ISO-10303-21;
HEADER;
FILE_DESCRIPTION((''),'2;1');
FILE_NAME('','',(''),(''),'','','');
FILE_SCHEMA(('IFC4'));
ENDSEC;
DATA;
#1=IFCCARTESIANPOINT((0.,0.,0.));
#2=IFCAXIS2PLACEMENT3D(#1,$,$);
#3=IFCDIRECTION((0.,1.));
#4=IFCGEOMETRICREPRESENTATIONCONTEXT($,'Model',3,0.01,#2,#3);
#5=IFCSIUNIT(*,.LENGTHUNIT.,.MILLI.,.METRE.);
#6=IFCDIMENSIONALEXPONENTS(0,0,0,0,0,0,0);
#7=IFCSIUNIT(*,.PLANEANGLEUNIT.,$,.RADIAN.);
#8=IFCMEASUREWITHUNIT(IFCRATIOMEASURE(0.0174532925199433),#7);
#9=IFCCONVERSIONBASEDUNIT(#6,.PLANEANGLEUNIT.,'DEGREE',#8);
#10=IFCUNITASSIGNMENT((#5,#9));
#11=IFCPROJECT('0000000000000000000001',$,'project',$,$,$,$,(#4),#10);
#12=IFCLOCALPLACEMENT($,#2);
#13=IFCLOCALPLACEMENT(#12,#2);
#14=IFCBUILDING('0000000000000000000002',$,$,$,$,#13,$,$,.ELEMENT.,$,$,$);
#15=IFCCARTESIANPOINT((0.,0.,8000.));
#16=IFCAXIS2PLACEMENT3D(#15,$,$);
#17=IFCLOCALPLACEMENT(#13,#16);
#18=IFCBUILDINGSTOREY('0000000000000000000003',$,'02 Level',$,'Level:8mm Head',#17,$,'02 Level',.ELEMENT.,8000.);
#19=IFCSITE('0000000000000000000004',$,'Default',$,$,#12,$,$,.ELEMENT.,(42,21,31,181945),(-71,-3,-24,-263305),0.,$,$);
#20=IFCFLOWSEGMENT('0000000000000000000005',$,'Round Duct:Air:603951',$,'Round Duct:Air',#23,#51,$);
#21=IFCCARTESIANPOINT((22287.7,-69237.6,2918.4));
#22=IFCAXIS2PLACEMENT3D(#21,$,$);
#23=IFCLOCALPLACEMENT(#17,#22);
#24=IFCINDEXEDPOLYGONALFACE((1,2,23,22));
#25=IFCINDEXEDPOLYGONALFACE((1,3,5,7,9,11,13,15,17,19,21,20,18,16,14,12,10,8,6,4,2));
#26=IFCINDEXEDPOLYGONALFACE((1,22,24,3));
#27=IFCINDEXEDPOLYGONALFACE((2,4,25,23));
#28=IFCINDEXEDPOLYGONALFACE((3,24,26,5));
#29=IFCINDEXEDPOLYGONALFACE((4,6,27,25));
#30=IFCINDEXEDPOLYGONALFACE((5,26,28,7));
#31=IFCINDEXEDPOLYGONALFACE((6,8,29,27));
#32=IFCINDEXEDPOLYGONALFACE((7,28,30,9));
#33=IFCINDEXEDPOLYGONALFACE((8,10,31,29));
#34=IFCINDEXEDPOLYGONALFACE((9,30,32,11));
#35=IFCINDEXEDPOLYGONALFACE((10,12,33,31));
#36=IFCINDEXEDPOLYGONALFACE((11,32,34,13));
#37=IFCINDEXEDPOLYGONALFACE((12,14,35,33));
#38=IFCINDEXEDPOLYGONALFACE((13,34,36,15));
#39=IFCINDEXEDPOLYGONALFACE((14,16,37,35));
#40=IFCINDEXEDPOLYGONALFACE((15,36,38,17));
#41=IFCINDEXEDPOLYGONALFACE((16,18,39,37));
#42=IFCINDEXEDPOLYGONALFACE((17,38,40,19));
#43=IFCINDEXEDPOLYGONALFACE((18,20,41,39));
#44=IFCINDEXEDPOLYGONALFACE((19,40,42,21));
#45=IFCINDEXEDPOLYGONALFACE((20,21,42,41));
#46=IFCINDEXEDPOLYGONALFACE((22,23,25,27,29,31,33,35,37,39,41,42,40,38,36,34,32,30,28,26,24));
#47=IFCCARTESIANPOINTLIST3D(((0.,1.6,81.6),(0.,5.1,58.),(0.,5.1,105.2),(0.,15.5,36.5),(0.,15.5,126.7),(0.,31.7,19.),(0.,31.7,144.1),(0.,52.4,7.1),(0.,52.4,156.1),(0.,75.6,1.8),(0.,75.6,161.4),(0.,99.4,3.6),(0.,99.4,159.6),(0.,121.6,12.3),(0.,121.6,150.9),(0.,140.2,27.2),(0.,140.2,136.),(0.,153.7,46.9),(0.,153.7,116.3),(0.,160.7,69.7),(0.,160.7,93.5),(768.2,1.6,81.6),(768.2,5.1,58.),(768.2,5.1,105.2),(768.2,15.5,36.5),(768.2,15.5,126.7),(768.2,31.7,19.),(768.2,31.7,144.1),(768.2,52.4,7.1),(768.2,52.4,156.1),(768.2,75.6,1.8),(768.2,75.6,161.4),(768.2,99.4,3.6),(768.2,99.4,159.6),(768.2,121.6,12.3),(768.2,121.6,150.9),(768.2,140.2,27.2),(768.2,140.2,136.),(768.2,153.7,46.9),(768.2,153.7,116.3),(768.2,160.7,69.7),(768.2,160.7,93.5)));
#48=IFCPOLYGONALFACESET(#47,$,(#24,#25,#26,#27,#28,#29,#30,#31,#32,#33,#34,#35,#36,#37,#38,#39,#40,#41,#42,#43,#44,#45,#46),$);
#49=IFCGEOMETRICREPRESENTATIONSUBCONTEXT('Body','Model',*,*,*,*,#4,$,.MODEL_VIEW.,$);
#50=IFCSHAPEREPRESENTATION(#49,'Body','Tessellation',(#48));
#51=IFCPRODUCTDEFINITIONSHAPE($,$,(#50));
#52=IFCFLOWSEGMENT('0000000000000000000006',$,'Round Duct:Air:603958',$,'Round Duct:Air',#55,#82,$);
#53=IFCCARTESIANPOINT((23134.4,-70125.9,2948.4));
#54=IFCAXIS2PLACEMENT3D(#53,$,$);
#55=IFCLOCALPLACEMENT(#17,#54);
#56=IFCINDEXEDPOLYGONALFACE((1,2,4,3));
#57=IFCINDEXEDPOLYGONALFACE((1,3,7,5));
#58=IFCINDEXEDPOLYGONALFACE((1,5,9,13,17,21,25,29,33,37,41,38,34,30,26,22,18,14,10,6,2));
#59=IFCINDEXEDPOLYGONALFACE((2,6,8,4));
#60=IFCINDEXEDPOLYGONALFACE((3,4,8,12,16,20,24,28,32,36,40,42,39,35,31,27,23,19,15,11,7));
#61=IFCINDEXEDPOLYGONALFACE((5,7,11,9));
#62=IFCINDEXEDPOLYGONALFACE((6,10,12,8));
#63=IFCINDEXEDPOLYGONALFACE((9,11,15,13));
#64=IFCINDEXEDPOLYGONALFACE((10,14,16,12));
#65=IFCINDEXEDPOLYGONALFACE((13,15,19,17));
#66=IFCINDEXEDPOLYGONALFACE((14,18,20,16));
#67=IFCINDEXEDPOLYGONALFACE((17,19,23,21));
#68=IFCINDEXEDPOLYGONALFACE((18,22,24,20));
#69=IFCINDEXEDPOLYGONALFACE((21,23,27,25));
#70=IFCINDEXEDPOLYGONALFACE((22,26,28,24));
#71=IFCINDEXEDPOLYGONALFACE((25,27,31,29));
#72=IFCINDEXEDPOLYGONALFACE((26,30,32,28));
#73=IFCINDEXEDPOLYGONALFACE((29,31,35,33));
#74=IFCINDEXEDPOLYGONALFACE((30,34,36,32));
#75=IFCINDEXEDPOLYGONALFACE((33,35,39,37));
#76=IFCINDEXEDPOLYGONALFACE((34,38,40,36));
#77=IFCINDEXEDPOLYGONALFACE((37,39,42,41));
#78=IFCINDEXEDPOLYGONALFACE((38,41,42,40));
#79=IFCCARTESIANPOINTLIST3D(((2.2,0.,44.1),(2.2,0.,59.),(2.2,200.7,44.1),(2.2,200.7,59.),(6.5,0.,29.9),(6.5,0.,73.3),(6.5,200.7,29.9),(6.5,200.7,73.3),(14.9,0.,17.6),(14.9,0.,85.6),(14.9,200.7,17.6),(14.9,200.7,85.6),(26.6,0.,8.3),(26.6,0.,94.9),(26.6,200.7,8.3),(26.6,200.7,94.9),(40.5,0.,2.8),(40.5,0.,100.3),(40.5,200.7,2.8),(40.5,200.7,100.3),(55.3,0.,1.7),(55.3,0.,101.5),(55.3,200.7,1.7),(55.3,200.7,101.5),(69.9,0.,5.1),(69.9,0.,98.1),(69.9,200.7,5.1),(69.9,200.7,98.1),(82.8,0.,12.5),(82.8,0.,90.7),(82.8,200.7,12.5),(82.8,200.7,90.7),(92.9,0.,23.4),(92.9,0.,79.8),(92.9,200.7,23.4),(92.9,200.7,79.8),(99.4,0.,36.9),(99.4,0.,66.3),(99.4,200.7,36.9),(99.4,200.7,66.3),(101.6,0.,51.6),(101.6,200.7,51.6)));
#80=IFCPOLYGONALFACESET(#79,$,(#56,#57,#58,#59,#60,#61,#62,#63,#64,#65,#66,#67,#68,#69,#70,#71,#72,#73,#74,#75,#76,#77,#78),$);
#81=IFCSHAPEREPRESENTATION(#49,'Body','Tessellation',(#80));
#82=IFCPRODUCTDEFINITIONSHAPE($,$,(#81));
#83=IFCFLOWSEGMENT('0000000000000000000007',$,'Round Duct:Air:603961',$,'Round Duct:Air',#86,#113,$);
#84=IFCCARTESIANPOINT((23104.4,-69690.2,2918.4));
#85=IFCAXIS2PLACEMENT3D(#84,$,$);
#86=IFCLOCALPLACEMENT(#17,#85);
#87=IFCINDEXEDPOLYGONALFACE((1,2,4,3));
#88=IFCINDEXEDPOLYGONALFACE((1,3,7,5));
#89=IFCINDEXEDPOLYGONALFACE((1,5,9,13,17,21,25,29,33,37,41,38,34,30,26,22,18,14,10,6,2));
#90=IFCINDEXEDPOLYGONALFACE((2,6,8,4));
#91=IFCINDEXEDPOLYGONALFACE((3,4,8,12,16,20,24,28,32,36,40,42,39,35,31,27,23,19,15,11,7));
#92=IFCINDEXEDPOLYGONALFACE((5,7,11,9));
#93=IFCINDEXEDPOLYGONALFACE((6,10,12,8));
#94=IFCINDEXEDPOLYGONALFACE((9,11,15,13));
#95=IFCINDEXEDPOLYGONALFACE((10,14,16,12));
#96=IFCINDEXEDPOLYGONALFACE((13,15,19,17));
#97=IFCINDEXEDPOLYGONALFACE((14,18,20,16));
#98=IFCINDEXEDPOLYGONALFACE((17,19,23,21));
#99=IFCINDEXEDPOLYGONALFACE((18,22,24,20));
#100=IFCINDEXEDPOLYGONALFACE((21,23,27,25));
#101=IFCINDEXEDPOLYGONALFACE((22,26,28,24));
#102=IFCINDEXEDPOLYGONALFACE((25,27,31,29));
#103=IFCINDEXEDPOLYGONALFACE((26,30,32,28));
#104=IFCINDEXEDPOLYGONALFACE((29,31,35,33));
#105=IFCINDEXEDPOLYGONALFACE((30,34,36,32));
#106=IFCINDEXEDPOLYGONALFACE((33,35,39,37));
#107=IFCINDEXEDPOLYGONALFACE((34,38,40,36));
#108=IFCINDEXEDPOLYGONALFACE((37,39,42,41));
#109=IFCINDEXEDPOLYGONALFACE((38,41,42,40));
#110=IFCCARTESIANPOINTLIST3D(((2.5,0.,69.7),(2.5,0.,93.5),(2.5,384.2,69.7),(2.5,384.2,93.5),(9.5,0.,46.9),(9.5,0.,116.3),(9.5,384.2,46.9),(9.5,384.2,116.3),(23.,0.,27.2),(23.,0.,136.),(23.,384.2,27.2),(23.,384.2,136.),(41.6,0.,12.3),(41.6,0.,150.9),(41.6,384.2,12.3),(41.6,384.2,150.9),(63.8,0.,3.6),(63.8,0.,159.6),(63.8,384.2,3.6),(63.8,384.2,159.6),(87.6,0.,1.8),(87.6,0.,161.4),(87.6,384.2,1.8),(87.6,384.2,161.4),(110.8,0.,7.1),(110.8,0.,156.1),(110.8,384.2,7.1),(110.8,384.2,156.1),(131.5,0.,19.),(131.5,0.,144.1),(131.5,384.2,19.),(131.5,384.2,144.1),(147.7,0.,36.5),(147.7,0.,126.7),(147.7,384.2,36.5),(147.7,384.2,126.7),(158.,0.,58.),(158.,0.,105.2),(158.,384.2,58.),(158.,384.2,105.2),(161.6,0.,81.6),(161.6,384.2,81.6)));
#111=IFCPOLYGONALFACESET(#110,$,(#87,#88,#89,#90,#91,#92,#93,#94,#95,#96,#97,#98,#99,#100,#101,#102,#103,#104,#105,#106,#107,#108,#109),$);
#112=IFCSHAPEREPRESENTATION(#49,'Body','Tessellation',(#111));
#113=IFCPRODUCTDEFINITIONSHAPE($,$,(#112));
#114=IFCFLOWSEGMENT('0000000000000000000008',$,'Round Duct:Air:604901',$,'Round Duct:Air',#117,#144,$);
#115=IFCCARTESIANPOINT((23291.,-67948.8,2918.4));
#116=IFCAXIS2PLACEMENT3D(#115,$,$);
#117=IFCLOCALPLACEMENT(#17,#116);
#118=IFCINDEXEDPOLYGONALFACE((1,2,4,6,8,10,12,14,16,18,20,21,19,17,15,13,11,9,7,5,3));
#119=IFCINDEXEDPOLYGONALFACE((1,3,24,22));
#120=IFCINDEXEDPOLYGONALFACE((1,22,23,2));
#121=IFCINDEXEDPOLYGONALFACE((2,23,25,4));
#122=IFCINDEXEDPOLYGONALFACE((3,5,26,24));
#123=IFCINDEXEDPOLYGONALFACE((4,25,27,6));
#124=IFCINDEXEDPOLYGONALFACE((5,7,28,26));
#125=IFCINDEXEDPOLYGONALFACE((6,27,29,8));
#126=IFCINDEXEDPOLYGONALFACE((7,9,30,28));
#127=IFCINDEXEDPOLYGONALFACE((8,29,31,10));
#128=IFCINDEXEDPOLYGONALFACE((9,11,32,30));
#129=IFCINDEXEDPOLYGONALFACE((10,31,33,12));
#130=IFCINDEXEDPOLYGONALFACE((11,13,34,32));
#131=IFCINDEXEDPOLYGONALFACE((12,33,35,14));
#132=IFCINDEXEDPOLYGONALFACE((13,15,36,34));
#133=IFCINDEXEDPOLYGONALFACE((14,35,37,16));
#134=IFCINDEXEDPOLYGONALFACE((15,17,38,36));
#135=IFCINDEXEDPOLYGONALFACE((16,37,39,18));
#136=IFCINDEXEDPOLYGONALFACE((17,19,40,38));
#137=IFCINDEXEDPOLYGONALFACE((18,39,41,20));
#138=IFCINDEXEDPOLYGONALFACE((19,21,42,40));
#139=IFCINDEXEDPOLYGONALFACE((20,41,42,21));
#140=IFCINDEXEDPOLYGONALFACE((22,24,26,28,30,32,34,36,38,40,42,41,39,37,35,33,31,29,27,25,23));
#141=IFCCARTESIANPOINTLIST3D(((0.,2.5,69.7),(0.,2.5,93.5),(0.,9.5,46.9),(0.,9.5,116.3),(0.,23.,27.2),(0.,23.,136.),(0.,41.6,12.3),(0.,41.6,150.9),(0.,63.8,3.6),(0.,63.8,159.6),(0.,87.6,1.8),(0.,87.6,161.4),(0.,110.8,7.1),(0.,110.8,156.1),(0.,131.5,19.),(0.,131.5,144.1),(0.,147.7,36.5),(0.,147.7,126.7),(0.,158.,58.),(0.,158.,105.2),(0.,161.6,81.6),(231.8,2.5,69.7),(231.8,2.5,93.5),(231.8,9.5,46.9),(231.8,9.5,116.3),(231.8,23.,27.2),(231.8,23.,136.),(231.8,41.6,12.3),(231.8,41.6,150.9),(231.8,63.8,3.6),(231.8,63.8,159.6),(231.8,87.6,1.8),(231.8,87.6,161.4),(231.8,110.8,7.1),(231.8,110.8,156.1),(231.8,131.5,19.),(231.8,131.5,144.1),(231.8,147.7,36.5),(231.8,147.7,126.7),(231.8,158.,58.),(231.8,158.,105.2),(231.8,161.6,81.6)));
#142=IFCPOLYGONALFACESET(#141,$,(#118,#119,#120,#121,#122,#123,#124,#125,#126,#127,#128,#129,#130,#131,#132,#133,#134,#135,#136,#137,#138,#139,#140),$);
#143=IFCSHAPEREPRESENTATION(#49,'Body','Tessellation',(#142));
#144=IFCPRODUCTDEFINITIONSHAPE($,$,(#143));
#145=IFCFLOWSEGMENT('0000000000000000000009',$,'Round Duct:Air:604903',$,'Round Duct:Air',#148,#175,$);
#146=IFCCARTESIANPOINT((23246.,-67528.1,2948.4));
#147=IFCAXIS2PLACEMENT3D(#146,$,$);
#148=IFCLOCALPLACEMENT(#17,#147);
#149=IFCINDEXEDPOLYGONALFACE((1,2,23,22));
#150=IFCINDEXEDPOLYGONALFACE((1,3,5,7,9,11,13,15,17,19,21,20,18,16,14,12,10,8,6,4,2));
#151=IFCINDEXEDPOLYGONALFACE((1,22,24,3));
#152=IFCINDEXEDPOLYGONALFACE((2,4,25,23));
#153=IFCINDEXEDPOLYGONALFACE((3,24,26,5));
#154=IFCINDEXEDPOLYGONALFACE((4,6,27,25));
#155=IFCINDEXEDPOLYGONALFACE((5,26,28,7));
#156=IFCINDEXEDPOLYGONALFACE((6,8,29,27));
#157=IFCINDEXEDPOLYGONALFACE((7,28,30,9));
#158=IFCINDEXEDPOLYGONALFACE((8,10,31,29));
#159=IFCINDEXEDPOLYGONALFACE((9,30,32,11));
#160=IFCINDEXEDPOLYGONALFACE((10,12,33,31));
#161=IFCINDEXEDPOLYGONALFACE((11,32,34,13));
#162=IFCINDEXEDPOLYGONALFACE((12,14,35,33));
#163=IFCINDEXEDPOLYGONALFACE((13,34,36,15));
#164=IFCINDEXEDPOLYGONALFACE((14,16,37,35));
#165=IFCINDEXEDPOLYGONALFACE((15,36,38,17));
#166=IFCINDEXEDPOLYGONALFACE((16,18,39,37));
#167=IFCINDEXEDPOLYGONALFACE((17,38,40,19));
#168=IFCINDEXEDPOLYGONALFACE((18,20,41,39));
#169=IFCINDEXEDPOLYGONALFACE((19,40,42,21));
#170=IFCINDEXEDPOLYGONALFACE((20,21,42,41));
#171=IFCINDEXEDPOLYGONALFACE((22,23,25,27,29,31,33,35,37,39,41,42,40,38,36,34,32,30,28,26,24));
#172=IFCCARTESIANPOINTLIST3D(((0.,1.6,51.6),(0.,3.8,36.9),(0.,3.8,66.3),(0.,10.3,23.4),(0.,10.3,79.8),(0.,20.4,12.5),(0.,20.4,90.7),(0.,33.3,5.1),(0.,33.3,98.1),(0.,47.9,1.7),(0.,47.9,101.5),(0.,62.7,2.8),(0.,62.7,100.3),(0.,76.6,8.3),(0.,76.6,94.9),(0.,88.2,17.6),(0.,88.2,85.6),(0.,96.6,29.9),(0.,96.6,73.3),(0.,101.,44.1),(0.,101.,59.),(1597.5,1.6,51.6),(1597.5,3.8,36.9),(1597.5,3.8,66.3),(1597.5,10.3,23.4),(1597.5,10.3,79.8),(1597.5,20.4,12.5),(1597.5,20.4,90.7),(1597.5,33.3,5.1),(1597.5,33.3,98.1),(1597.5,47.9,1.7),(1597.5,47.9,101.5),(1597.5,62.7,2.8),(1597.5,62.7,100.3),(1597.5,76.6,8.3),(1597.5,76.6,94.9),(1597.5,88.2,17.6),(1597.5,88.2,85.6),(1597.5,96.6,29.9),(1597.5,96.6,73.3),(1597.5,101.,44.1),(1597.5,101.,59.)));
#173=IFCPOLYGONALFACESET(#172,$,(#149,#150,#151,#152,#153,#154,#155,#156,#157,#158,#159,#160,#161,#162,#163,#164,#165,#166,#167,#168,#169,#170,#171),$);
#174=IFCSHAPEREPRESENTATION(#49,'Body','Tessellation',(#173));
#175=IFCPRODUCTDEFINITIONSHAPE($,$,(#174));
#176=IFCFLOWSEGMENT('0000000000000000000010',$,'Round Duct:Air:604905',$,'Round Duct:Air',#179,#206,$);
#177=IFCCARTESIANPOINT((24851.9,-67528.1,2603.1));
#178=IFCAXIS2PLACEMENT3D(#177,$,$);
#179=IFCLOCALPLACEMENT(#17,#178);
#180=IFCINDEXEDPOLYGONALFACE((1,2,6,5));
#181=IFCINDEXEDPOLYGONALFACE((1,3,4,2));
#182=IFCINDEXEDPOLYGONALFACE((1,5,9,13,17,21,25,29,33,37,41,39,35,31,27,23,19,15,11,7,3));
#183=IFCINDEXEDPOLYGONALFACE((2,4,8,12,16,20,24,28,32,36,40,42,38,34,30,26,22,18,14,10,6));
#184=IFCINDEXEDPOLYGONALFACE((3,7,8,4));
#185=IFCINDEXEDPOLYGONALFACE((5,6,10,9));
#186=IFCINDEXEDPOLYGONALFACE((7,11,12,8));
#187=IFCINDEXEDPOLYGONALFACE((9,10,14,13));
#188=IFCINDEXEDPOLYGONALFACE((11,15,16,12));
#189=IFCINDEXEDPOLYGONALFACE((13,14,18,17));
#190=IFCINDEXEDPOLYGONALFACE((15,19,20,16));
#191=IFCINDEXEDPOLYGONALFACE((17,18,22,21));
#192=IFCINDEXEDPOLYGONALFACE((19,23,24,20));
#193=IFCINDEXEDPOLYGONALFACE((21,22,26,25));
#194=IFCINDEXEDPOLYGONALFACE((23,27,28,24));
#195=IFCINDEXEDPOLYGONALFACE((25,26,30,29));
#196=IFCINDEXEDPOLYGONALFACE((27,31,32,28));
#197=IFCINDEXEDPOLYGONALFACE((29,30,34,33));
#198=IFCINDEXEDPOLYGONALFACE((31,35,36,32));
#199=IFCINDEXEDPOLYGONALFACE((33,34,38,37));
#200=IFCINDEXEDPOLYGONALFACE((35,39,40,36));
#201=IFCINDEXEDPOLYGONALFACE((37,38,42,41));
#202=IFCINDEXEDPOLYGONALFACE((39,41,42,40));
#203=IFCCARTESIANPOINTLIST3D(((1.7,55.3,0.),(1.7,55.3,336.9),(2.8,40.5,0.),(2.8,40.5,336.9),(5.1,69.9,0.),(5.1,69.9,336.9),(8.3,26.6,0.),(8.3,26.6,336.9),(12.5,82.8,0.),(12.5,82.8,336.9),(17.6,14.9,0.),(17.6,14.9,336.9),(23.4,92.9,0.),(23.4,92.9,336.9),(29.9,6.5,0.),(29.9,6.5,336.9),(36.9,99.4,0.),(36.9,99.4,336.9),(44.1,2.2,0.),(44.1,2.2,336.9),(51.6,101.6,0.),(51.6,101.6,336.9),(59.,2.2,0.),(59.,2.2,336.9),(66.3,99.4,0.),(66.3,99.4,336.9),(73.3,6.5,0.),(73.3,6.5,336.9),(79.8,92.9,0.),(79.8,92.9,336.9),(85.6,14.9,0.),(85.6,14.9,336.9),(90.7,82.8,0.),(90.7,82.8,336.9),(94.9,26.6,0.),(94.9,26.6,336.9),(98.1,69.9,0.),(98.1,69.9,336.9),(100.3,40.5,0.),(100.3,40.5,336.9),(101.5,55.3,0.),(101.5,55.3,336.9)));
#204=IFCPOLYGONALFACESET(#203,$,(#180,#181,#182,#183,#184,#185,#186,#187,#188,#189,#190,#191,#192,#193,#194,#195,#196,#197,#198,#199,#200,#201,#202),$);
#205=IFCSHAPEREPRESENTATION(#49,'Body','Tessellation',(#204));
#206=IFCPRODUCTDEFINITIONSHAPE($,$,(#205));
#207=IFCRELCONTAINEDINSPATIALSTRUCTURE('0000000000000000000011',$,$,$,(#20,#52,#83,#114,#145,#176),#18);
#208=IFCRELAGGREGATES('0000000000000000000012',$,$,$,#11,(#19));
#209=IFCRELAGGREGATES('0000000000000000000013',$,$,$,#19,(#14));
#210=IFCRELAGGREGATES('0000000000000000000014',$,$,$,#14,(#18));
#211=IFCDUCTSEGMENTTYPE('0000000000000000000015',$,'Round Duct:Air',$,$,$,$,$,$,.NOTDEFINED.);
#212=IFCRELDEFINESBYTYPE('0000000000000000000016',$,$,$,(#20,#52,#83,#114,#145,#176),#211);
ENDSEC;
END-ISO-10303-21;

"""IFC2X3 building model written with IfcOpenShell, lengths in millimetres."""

from ifc_helpers import new_model, entity, si_unit, converted_unit, direction, frame, origin, origin_2d_with_axis, place, context, subcontext, project, spatial, circle, extrude, type_object, element, save


model = new_model("IFC2X3")

# Units and contexts
model_context = context("Model", 3, precision=0.01, world=origin(), true_north=direction((0.0, 1.0)))
body_context = subcontext(model_context, "Body", "Model", "MODEL_VIEW")
ifc_project = project(units=[si_unit("LENGTHUNIT", "METRE", prefix="MILLI"), converted_unit("PLANEANGLEUNIT", "DEGREE", entity("IfcRatioMeasure", 0.0174532925199433), si_unit("PLANEANGLEUNIT", "RADIAN"), dimensions=[0, 0, 0, 0, 0, 0, 0])], contexts=[model_context])

# Site, building, storey
site_placement = place(None, origin())
site = spatial("IfcSite", under=ifc_project, at=site_placement, Name="Default", CompositionType="ELEMENT", RefLatitude=(42, 21, 31, 181945), RefLongitude=(-71, -3, -24, -263305), RefElevation=0.0)
building_placement = place(site_placement, origin())
building = spatial("IfcBuilding", under=site, at=building_placement, CompositionType="ELEMENT")
storey_placement = place(building_placement, frame((0.0, 0.0, 8000.0)))
storey = spatial("IfcBuildingStorey", under=building, at=storey_placement, Name="02 Level", ObjectType="Level:8mm Head", LongName="02 Level", CompositionType="ELEMENT", Elevation=8000.0)

# Flow segments
duct_segment_type_1 = type_object("IfcDuctSegmentType", Name="Round Duct:Air", PredefinedType="NOTDEFINED")
flow_segment_1_placement = place(storey_placement, frame((22287.7, -69237.6, 2918.4)))
element("IfcFlowSegment", 1, at=flow_segment_1_placement, inside=storey, type_object=duct_segment_type_1, Name="Round Duct:Air:603951", ObjectType="Round Duct:Air", context=body_context, shape_type="SweptSolid", body=[
    extrude(circle(Radius=80.0, at=origin_2d_with_axis()), frame((0.0, 81.6, 81.6), z_axis=(1.0, 0.0, 0.0), x_axis=(0.0, -1.0, 0.0)), (0.0, 0.0, 1.0), 768.2),
])
flow_segment_2_placement = place(storey_placement, frame((23134.4, -70125.9, 2948.4)))
element("IfcFlowSegment", 2, at=flow_segment_2_placement, inside=storey, type_object=duct_segment_type_1, Name="Round Duct:Air:603958", ObjectType="Round Duct:Air", context=body_context, shape_type="SweptSolid", body=[
    extrude(circle(Radius=50.0, at=origin_2d_with_axis()), frame((51.6, 0.0, 51.6), z_axis=(0.0, 1.0, 0.0), x_axis=(1.0, 0.0, 0.0)), (0.0, 0.0, 1.0), 200.7),
])
flow_segment_3_placement = place(storey_placement, frame((23104.4, -69690.2, 2918.4)))
element("IfcFlowSegment", 3, at=flow_segment_3_placement, inside=storey, type_object=duct_segment_type_1, Name="Round Duct:Air:603961", ObjectType="Round Duct:Air", context=body_context, shape_type="SweptSolid", body=[
    extrude(circle(Radius=80.0, at=origin_2d_with_axis()), frame((81.6, 0.0, 81.6), z_axis=(0.0, 1.0, 0.0), x_axis=(1.0, 0.0, 0.0)), (0.0, 0.0, 1.0), 384.2),
])
flow_segment_4_placement = place(storey_placement, frame((23291.0, -67948.8, 2918.4)))
element("IfcFlowSegment", 4, at=flow_segment_4_placement, inside=storey, type_object=duct_segment_type_1, Name="Round Duct:Air:604901", ObjectType="Round Duct:Air", context=body_context, shape_type="SweptSolid", body=[
    extrude(circle(Radius=80.0, at=origin_2d_with_axis()), frame((0.0, 81.6, 81.6), z_axis=(1.0, 0.0, 0.0), x_axis=(0.0, 1.0, 0.0)), (0.0, 0.0, 1.0), 231.8),
])
flow_segment_5_placement = place(storey_placement, frame((23246.0, -67528.1, 2948.4)))
element("IfcFlowSegment", 5, at=flow_segment_5_placement, inside=storey, type_object=duct_segment_type_1, Name="Round Duct:Air:604903", ObjectType="Round Duct:Air", context=body_context, shape_type="SweptSolid", body=[
    extrude(circle(Radius=50.0, at=origin_2d_with_axis()), frame((0.0, 51.6, 51.6), z_axis=(1.0, 0.0, 0.0), x_axis=(0.0, -1.0, 0.0)), (0.0, 0.0, 1.0), 1597.5),
])
flow_segment_6_placement = place(storey_placement, frame((24851.9, -67528.1, 2603.1)))
element("IfcFlowSegment", 6, at=flow_segment_6_placement, inside=storey, type_object=duct_segment_type_1, Name="Round Duct:Air:604905", ObjectType="Round Duct:Air", context=body_context, shape_type="SweptSolid", body=[
    extrude(circle(Radius=50.0, at=origin_2d_with_axis()), frame((51.6, 51.6, 0.0), z_axis=(0.0, 0.0, 1.0), x_axis=(0.0, 1.0, 0.0)), (0.0, 0.0, 1.0), 336.9),
])

save(model, "model.ifc")
